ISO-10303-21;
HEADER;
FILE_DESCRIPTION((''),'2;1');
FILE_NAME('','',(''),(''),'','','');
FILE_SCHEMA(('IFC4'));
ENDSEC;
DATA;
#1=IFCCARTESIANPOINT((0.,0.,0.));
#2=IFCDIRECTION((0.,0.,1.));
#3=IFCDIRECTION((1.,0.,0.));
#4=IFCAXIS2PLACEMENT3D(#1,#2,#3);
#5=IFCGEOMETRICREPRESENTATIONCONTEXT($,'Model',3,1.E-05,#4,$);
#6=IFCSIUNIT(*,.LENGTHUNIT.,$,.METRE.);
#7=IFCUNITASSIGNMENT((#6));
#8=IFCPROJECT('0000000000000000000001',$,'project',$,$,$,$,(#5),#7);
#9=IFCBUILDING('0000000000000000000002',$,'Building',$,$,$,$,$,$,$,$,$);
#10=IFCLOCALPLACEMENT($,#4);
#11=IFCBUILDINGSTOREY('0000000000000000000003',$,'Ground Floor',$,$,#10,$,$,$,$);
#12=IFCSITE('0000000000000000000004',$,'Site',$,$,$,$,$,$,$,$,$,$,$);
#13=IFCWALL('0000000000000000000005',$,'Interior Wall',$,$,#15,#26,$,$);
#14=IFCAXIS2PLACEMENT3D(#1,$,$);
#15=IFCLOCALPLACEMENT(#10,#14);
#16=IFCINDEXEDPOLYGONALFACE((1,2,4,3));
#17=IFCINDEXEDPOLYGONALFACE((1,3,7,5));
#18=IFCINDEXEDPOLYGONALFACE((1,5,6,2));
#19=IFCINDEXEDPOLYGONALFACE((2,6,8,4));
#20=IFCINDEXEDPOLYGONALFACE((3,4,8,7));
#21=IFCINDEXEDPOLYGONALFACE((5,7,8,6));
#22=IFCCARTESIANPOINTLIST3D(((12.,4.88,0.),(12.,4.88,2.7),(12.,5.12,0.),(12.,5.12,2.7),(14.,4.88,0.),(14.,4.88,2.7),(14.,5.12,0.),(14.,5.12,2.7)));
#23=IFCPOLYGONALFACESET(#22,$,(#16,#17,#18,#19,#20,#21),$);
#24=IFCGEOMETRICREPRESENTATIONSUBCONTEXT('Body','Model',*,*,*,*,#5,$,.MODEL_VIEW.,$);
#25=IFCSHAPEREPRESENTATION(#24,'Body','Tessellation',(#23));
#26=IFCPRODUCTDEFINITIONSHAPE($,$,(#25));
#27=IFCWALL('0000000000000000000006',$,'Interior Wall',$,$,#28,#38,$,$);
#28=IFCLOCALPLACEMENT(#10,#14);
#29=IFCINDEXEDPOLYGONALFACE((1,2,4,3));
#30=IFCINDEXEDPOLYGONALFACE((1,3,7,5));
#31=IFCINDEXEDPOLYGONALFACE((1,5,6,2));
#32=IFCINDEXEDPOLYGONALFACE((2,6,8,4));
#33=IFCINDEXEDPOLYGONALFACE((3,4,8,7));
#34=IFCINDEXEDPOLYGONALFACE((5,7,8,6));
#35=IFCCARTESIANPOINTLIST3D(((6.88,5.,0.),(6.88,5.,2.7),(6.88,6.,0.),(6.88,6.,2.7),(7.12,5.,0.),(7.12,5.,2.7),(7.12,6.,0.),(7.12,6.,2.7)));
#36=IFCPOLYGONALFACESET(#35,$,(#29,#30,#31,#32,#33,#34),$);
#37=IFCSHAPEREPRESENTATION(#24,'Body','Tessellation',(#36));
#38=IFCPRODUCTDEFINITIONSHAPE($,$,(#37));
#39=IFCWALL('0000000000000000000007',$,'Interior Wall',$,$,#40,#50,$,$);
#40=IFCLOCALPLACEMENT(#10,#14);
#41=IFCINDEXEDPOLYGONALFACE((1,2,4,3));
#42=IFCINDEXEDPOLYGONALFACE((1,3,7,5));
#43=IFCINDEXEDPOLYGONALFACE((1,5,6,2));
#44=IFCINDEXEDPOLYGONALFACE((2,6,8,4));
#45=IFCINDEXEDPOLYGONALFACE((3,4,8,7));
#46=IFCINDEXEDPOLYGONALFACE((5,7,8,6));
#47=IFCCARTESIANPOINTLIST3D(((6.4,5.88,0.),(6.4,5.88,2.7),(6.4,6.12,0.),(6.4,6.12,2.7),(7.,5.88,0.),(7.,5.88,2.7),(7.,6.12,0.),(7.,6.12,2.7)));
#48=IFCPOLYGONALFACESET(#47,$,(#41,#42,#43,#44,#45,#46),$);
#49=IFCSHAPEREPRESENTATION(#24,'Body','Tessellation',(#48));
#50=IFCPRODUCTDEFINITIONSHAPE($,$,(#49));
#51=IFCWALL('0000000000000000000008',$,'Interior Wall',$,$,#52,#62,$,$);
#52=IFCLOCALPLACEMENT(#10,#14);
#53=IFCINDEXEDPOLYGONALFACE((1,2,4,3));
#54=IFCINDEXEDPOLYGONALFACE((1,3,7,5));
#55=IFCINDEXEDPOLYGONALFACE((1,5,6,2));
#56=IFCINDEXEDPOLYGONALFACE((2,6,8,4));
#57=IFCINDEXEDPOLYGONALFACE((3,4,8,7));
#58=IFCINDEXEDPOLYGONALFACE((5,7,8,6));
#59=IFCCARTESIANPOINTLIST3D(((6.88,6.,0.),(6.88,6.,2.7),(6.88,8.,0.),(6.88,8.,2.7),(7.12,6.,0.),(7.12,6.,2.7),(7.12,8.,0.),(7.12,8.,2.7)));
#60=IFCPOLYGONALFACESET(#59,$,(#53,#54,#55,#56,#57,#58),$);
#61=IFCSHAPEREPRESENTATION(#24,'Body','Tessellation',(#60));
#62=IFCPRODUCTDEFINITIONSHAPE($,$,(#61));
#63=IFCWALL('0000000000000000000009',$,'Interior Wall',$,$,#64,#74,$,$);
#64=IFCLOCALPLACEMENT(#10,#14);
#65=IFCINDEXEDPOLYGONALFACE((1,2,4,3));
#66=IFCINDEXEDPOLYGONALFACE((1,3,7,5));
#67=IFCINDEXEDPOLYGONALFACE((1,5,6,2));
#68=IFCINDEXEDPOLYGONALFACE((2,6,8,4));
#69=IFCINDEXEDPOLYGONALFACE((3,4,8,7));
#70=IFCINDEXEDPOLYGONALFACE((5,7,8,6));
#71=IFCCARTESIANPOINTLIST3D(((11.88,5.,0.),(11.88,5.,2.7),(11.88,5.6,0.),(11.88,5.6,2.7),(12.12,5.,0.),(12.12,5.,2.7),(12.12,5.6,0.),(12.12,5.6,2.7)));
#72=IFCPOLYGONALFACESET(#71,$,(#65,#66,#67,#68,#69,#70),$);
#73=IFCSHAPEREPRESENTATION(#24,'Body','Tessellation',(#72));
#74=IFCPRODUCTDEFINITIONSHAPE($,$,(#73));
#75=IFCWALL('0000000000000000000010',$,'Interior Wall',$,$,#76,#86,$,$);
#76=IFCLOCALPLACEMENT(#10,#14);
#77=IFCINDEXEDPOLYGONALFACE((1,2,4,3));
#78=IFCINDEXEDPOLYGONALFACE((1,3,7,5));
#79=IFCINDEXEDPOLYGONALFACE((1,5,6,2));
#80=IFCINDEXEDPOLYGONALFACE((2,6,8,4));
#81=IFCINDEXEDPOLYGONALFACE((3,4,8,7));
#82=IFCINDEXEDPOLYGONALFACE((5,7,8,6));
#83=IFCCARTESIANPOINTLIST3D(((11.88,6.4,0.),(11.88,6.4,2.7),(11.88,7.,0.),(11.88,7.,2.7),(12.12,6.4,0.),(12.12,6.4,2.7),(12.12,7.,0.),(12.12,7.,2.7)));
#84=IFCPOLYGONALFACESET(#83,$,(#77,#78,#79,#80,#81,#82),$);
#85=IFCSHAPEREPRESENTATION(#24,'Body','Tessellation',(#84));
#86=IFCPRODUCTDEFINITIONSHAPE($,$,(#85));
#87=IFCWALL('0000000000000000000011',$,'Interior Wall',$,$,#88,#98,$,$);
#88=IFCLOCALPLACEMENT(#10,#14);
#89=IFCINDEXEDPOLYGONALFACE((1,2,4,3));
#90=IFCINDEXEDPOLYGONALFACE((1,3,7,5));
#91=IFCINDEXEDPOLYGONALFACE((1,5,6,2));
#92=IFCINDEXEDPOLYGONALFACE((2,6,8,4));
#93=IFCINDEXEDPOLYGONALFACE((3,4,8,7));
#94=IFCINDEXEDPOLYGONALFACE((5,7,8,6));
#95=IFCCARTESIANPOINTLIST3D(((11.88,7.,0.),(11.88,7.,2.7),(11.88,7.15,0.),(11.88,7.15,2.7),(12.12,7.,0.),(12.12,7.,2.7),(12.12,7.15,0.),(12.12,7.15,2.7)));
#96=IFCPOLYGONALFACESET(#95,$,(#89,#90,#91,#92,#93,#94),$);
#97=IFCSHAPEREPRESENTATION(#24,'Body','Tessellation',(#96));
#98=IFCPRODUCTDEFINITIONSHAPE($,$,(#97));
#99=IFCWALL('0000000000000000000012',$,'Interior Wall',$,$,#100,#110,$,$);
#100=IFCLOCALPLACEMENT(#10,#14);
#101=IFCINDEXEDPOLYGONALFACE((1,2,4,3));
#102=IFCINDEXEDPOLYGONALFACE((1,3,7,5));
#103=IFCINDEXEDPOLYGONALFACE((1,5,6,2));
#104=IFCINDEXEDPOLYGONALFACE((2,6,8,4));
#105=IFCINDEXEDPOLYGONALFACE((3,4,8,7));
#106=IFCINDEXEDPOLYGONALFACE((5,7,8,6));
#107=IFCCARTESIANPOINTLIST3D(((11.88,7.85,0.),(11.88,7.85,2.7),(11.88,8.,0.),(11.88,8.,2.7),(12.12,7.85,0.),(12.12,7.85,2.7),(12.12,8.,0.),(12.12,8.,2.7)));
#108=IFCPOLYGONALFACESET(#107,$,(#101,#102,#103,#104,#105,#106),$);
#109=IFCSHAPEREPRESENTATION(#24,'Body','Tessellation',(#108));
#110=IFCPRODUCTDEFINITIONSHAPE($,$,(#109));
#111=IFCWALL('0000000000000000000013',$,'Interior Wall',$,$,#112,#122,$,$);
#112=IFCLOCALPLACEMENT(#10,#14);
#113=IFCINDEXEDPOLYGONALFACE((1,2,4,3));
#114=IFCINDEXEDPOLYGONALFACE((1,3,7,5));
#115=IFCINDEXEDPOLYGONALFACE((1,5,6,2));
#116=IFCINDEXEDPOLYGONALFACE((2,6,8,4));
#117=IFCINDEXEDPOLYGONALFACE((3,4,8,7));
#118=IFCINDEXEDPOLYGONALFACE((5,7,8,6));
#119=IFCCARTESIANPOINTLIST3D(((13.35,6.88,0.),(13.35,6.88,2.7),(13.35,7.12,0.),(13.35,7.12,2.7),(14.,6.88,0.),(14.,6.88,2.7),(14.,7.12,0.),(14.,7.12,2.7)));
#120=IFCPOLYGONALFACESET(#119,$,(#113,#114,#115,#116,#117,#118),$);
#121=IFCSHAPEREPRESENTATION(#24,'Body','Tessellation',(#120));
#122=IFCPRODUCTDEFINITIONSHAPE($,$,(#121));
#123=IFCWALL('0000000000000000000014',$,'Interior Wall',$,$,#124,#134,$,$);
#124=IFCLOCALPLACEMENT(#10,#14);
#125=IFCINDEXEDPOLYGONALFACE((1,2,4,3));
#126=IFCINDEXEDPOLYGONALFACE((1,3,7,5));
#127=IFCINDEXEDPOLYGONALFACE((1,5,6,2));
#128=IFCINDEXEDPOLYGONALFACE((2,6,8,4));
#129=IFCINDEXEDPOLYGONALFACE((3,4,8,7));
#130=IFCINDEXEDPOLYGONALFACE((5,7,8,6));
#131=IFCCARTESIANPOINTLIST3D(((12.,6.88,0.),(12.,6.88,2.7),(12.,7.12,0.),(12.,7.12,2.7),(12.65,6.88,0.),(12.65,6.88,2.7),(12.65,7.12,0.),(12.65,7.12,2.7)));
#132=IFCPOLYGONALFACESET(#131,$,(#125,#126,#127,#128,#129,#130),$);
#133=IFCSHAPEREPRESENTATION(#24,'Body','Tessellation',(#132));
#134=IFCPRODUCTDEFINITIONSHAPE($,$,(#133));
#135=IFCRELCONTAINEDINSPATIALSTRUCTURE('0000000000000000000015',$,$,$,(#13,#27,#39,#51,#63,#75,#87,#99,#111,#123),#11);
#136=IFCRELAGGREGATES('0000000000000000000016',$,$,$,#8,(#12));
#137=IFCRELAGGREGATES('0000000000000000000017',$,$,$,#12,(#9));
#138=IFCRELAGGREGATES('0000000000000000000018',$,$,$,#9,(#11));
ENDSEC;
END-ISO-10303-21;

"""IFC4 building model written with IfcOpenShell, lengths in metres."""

from ifc_helpers import new_model, si_unit, frame, origin_with_axes, place, context, subcontext, project, spatial, indexed_curve, outline, extrude, element, save


model = new_model("IFC4")

# Units and contexts
model_context = context("Model", 3, precision=1e-05, world=origin_with_axes())
body_context = subcontext(model_context, "Body", "Model", "MODEL_VIEW")
ifc_project = project(units=[si_unit("LENGTHUNIT", "METRE")], contexts=[model_context])

# Site, building, storey
site = spatial("IfcSite", under=ifc_project, Name="Site")
building = spatial("IfcBuilding", under=site, Name="Building")
storey_placement = place(None, origin_with_axes())
storey = spatial("IfcBuildingStorey", under=building, at=storey_placement, Name="Ground Floor")

# Walls
wall_1_placement = place(storey_placement, frame((14.0, 5.0, 0.0), z_axis=(0.0, 0.0, 1.0), x_axis=(-1.0, 0.0, 0.0)))
element("IfcWall", 1, at=wall_1_placement, inside=storey, Name="Interior Wall", context=body_context, shape_type="SweptSolid", body=[
    extrude(outline(indexed_curve([(0.0, 0.0), (0.0, 0.24), (2.0, 0.24), (2.0, 0.0), (0.0, 0.0)], self_intersect=False)), frame((0.0, -0.12, 0.0), z_axis=(0.0, 0.0, 1.0), x_axis=(1.0, 0.0, 0.0)), (0.0, 0.0, 1.0), 2.7),
])
wall_2_placement = place(storey_placement, frame((7.0, 5.0, 0.0), z_axis=(0.0, 0.0, 1.0), x_axis=(0.0, 1.0, 0.0)))
element("IfcWall", 2, at=wall_2_placement, inside=storey, Name="Interior Wall", context=body_context, shape_type="SweptSolid", body=[
    extrude(outline(indexed_curve([(0.0, 0.0), (0.0, 0.24), (1.0, 0.24), (1.0, 0.0), (0.0, 0.0)], self_intersect=False)), frame((0.0, -0.12, 0.0), z_axis=(0.0, 0.0, 1.0), x_axis=(1.0, 0.0, 0.0)), (0.0, 0.0, 1.0), 2.7),
])
wall_3_placement = place(storey_placement, frame((7.0, 6.0, 0.0), z_axis=(0.0, 0.0, 1.0), x_axis=(-1.0, 0.0, 0.0)))
element("IfcWall", 3, at=wall_3_placement, inside=storey, Name="Interior Wall", context=body_context, shape_type="SweptSolid", body=[
    extrude(outline(indexed_curve([(0.0, 0.0), (0.0, 0.24), (0.6, 0.24), (0.6, 0.0), (0.0, 0.0)], self_intersect=False)), frame((0.0, -0.12, 0.0), z_axis=(0.0, 0.0, 1.0), x_axis=(1.0, 0.0, 0.0)), (0.0, 0.0, 1.0), 2.7),
])
wall_4_placement = place(storey_placement, frame((7.0, 6.0, 0.0), z_axis=(0.0, 0.0, 1.0), x_axis=(0.0, 1.0, 0.0)))
element("IfcWall", 4, at=wall_4_placement, inside=storey, Name="Interior Wall", context=body_context, shape_type="SweptSolid", body=[
    extrude(outline(indexed_curve([(0.0, 0.0), (0.0, 0.24), (2.0, 0.24), (2.0, 0.0), (0.0, 0.0)], self_intersect=False)), frame((0.0, -0.12, 0.0), z_axis=(0.0, 0.0, 1.0), x_axis=(1.0, 0.0, 0.0)), (0.0, 0.0, 1.0), 2.7),
])
for number, where, z_axis, x_axis, name in (
    (5, (12.0, 5.0, 0.0), (0.0, 0.0, 1.0), (0.0, 1.0, 0.0), "Interior Wall"),
    (6, (12.0, 6.4, 0.0), (0.0, 0.0, 1.0), (0.0, 1.0, 0.0), "Interior Wall"),
):
    element("IfcWall", number, at=place(storey_placement, frame(where, z_axis=z_axis, x_axis=x_axis)), inside=storey, Name=name, context=body_context, shape_type="SweptSolid", body=[
        extrude(outline(indexed_curve([(0.0, 0.0), (0.0, 0.24), (0.6, 0.24), (0.6, 0.0), (0.0, 0.0)], self_intersect=False)), frame((0.0, -0.12, 0.0), z_axis=(0.0, 0.0, 1.0), x_axis=(1.0, 0.0, 0.0)), (0.0, 0.0, 1.0), 2.7),
    ])
for number, where, z_axis, x_axis, name in (
    (7, (12.0, 7.0, 0.0), (0.0, 0.0, 1.0), (0.0, 1.0, 0.0), "Interior Wall"),
    (8, (12.0, 7.85, 0.0), (0.0, 0.0, 1.0), (0.0, 1.0, 0.0), "Interior Wall"),
):
    element("IfcWall", number, at=place(storey_placement, frame(where, z_axis=z_axis, x_axis=x_axis)), inside=storey, Name=name, context=body_context, shape_type="SweptSolid", body=[
        extrude(outline(indexed_curve([(0.0, 0.0), (0.0, 0.24), (0.15, 0.24), (0.15, 0.0), (0.0, 0.0)], self_intersect=False)), frame((0.0, -0.12, 0.0), z_axis=(0.0, 0.0, 1.0), x_axis=(1.0, 0.0, 0.0)), (0.0, 0.0, 1.0), 2.7),
    ])
for number, where, z_axis, x_axis, name in (
    (9, (14.0, 7.0, 0.0), (0.0, 0.0, 1.0), (-1.0, 0.0, 0.0), "Interior Wall"),
    (10, (12.65, 7.0, 0.0), (0.0, 0.0, 1.0), (-1.0, 0.0, 0.0), "Interior Wall"),
):
    element("IfcWall", number, at=place(storey_placement, frame(where, z_axis=z_axis, x_axis=x_axis)), inside=storey, Name=name, context=body_context, shape_type="SweptSolid", body=[
        extrude(outline(indexed_curve([(0.0, 0.0), (0.0, 0.24), (0.65, 0.24), (0.65, 0.0), (0.0, 0.0)], self_intersect=False)), frame((0.0, -0.12, 0.0), z_axis=(0.0, 0.0, 1.0), x_axis=(1.0, 0.0, 0.0)), (0.0, 0.0, 1.0), 2.7),
    ])

save(model, "model.ifc")
